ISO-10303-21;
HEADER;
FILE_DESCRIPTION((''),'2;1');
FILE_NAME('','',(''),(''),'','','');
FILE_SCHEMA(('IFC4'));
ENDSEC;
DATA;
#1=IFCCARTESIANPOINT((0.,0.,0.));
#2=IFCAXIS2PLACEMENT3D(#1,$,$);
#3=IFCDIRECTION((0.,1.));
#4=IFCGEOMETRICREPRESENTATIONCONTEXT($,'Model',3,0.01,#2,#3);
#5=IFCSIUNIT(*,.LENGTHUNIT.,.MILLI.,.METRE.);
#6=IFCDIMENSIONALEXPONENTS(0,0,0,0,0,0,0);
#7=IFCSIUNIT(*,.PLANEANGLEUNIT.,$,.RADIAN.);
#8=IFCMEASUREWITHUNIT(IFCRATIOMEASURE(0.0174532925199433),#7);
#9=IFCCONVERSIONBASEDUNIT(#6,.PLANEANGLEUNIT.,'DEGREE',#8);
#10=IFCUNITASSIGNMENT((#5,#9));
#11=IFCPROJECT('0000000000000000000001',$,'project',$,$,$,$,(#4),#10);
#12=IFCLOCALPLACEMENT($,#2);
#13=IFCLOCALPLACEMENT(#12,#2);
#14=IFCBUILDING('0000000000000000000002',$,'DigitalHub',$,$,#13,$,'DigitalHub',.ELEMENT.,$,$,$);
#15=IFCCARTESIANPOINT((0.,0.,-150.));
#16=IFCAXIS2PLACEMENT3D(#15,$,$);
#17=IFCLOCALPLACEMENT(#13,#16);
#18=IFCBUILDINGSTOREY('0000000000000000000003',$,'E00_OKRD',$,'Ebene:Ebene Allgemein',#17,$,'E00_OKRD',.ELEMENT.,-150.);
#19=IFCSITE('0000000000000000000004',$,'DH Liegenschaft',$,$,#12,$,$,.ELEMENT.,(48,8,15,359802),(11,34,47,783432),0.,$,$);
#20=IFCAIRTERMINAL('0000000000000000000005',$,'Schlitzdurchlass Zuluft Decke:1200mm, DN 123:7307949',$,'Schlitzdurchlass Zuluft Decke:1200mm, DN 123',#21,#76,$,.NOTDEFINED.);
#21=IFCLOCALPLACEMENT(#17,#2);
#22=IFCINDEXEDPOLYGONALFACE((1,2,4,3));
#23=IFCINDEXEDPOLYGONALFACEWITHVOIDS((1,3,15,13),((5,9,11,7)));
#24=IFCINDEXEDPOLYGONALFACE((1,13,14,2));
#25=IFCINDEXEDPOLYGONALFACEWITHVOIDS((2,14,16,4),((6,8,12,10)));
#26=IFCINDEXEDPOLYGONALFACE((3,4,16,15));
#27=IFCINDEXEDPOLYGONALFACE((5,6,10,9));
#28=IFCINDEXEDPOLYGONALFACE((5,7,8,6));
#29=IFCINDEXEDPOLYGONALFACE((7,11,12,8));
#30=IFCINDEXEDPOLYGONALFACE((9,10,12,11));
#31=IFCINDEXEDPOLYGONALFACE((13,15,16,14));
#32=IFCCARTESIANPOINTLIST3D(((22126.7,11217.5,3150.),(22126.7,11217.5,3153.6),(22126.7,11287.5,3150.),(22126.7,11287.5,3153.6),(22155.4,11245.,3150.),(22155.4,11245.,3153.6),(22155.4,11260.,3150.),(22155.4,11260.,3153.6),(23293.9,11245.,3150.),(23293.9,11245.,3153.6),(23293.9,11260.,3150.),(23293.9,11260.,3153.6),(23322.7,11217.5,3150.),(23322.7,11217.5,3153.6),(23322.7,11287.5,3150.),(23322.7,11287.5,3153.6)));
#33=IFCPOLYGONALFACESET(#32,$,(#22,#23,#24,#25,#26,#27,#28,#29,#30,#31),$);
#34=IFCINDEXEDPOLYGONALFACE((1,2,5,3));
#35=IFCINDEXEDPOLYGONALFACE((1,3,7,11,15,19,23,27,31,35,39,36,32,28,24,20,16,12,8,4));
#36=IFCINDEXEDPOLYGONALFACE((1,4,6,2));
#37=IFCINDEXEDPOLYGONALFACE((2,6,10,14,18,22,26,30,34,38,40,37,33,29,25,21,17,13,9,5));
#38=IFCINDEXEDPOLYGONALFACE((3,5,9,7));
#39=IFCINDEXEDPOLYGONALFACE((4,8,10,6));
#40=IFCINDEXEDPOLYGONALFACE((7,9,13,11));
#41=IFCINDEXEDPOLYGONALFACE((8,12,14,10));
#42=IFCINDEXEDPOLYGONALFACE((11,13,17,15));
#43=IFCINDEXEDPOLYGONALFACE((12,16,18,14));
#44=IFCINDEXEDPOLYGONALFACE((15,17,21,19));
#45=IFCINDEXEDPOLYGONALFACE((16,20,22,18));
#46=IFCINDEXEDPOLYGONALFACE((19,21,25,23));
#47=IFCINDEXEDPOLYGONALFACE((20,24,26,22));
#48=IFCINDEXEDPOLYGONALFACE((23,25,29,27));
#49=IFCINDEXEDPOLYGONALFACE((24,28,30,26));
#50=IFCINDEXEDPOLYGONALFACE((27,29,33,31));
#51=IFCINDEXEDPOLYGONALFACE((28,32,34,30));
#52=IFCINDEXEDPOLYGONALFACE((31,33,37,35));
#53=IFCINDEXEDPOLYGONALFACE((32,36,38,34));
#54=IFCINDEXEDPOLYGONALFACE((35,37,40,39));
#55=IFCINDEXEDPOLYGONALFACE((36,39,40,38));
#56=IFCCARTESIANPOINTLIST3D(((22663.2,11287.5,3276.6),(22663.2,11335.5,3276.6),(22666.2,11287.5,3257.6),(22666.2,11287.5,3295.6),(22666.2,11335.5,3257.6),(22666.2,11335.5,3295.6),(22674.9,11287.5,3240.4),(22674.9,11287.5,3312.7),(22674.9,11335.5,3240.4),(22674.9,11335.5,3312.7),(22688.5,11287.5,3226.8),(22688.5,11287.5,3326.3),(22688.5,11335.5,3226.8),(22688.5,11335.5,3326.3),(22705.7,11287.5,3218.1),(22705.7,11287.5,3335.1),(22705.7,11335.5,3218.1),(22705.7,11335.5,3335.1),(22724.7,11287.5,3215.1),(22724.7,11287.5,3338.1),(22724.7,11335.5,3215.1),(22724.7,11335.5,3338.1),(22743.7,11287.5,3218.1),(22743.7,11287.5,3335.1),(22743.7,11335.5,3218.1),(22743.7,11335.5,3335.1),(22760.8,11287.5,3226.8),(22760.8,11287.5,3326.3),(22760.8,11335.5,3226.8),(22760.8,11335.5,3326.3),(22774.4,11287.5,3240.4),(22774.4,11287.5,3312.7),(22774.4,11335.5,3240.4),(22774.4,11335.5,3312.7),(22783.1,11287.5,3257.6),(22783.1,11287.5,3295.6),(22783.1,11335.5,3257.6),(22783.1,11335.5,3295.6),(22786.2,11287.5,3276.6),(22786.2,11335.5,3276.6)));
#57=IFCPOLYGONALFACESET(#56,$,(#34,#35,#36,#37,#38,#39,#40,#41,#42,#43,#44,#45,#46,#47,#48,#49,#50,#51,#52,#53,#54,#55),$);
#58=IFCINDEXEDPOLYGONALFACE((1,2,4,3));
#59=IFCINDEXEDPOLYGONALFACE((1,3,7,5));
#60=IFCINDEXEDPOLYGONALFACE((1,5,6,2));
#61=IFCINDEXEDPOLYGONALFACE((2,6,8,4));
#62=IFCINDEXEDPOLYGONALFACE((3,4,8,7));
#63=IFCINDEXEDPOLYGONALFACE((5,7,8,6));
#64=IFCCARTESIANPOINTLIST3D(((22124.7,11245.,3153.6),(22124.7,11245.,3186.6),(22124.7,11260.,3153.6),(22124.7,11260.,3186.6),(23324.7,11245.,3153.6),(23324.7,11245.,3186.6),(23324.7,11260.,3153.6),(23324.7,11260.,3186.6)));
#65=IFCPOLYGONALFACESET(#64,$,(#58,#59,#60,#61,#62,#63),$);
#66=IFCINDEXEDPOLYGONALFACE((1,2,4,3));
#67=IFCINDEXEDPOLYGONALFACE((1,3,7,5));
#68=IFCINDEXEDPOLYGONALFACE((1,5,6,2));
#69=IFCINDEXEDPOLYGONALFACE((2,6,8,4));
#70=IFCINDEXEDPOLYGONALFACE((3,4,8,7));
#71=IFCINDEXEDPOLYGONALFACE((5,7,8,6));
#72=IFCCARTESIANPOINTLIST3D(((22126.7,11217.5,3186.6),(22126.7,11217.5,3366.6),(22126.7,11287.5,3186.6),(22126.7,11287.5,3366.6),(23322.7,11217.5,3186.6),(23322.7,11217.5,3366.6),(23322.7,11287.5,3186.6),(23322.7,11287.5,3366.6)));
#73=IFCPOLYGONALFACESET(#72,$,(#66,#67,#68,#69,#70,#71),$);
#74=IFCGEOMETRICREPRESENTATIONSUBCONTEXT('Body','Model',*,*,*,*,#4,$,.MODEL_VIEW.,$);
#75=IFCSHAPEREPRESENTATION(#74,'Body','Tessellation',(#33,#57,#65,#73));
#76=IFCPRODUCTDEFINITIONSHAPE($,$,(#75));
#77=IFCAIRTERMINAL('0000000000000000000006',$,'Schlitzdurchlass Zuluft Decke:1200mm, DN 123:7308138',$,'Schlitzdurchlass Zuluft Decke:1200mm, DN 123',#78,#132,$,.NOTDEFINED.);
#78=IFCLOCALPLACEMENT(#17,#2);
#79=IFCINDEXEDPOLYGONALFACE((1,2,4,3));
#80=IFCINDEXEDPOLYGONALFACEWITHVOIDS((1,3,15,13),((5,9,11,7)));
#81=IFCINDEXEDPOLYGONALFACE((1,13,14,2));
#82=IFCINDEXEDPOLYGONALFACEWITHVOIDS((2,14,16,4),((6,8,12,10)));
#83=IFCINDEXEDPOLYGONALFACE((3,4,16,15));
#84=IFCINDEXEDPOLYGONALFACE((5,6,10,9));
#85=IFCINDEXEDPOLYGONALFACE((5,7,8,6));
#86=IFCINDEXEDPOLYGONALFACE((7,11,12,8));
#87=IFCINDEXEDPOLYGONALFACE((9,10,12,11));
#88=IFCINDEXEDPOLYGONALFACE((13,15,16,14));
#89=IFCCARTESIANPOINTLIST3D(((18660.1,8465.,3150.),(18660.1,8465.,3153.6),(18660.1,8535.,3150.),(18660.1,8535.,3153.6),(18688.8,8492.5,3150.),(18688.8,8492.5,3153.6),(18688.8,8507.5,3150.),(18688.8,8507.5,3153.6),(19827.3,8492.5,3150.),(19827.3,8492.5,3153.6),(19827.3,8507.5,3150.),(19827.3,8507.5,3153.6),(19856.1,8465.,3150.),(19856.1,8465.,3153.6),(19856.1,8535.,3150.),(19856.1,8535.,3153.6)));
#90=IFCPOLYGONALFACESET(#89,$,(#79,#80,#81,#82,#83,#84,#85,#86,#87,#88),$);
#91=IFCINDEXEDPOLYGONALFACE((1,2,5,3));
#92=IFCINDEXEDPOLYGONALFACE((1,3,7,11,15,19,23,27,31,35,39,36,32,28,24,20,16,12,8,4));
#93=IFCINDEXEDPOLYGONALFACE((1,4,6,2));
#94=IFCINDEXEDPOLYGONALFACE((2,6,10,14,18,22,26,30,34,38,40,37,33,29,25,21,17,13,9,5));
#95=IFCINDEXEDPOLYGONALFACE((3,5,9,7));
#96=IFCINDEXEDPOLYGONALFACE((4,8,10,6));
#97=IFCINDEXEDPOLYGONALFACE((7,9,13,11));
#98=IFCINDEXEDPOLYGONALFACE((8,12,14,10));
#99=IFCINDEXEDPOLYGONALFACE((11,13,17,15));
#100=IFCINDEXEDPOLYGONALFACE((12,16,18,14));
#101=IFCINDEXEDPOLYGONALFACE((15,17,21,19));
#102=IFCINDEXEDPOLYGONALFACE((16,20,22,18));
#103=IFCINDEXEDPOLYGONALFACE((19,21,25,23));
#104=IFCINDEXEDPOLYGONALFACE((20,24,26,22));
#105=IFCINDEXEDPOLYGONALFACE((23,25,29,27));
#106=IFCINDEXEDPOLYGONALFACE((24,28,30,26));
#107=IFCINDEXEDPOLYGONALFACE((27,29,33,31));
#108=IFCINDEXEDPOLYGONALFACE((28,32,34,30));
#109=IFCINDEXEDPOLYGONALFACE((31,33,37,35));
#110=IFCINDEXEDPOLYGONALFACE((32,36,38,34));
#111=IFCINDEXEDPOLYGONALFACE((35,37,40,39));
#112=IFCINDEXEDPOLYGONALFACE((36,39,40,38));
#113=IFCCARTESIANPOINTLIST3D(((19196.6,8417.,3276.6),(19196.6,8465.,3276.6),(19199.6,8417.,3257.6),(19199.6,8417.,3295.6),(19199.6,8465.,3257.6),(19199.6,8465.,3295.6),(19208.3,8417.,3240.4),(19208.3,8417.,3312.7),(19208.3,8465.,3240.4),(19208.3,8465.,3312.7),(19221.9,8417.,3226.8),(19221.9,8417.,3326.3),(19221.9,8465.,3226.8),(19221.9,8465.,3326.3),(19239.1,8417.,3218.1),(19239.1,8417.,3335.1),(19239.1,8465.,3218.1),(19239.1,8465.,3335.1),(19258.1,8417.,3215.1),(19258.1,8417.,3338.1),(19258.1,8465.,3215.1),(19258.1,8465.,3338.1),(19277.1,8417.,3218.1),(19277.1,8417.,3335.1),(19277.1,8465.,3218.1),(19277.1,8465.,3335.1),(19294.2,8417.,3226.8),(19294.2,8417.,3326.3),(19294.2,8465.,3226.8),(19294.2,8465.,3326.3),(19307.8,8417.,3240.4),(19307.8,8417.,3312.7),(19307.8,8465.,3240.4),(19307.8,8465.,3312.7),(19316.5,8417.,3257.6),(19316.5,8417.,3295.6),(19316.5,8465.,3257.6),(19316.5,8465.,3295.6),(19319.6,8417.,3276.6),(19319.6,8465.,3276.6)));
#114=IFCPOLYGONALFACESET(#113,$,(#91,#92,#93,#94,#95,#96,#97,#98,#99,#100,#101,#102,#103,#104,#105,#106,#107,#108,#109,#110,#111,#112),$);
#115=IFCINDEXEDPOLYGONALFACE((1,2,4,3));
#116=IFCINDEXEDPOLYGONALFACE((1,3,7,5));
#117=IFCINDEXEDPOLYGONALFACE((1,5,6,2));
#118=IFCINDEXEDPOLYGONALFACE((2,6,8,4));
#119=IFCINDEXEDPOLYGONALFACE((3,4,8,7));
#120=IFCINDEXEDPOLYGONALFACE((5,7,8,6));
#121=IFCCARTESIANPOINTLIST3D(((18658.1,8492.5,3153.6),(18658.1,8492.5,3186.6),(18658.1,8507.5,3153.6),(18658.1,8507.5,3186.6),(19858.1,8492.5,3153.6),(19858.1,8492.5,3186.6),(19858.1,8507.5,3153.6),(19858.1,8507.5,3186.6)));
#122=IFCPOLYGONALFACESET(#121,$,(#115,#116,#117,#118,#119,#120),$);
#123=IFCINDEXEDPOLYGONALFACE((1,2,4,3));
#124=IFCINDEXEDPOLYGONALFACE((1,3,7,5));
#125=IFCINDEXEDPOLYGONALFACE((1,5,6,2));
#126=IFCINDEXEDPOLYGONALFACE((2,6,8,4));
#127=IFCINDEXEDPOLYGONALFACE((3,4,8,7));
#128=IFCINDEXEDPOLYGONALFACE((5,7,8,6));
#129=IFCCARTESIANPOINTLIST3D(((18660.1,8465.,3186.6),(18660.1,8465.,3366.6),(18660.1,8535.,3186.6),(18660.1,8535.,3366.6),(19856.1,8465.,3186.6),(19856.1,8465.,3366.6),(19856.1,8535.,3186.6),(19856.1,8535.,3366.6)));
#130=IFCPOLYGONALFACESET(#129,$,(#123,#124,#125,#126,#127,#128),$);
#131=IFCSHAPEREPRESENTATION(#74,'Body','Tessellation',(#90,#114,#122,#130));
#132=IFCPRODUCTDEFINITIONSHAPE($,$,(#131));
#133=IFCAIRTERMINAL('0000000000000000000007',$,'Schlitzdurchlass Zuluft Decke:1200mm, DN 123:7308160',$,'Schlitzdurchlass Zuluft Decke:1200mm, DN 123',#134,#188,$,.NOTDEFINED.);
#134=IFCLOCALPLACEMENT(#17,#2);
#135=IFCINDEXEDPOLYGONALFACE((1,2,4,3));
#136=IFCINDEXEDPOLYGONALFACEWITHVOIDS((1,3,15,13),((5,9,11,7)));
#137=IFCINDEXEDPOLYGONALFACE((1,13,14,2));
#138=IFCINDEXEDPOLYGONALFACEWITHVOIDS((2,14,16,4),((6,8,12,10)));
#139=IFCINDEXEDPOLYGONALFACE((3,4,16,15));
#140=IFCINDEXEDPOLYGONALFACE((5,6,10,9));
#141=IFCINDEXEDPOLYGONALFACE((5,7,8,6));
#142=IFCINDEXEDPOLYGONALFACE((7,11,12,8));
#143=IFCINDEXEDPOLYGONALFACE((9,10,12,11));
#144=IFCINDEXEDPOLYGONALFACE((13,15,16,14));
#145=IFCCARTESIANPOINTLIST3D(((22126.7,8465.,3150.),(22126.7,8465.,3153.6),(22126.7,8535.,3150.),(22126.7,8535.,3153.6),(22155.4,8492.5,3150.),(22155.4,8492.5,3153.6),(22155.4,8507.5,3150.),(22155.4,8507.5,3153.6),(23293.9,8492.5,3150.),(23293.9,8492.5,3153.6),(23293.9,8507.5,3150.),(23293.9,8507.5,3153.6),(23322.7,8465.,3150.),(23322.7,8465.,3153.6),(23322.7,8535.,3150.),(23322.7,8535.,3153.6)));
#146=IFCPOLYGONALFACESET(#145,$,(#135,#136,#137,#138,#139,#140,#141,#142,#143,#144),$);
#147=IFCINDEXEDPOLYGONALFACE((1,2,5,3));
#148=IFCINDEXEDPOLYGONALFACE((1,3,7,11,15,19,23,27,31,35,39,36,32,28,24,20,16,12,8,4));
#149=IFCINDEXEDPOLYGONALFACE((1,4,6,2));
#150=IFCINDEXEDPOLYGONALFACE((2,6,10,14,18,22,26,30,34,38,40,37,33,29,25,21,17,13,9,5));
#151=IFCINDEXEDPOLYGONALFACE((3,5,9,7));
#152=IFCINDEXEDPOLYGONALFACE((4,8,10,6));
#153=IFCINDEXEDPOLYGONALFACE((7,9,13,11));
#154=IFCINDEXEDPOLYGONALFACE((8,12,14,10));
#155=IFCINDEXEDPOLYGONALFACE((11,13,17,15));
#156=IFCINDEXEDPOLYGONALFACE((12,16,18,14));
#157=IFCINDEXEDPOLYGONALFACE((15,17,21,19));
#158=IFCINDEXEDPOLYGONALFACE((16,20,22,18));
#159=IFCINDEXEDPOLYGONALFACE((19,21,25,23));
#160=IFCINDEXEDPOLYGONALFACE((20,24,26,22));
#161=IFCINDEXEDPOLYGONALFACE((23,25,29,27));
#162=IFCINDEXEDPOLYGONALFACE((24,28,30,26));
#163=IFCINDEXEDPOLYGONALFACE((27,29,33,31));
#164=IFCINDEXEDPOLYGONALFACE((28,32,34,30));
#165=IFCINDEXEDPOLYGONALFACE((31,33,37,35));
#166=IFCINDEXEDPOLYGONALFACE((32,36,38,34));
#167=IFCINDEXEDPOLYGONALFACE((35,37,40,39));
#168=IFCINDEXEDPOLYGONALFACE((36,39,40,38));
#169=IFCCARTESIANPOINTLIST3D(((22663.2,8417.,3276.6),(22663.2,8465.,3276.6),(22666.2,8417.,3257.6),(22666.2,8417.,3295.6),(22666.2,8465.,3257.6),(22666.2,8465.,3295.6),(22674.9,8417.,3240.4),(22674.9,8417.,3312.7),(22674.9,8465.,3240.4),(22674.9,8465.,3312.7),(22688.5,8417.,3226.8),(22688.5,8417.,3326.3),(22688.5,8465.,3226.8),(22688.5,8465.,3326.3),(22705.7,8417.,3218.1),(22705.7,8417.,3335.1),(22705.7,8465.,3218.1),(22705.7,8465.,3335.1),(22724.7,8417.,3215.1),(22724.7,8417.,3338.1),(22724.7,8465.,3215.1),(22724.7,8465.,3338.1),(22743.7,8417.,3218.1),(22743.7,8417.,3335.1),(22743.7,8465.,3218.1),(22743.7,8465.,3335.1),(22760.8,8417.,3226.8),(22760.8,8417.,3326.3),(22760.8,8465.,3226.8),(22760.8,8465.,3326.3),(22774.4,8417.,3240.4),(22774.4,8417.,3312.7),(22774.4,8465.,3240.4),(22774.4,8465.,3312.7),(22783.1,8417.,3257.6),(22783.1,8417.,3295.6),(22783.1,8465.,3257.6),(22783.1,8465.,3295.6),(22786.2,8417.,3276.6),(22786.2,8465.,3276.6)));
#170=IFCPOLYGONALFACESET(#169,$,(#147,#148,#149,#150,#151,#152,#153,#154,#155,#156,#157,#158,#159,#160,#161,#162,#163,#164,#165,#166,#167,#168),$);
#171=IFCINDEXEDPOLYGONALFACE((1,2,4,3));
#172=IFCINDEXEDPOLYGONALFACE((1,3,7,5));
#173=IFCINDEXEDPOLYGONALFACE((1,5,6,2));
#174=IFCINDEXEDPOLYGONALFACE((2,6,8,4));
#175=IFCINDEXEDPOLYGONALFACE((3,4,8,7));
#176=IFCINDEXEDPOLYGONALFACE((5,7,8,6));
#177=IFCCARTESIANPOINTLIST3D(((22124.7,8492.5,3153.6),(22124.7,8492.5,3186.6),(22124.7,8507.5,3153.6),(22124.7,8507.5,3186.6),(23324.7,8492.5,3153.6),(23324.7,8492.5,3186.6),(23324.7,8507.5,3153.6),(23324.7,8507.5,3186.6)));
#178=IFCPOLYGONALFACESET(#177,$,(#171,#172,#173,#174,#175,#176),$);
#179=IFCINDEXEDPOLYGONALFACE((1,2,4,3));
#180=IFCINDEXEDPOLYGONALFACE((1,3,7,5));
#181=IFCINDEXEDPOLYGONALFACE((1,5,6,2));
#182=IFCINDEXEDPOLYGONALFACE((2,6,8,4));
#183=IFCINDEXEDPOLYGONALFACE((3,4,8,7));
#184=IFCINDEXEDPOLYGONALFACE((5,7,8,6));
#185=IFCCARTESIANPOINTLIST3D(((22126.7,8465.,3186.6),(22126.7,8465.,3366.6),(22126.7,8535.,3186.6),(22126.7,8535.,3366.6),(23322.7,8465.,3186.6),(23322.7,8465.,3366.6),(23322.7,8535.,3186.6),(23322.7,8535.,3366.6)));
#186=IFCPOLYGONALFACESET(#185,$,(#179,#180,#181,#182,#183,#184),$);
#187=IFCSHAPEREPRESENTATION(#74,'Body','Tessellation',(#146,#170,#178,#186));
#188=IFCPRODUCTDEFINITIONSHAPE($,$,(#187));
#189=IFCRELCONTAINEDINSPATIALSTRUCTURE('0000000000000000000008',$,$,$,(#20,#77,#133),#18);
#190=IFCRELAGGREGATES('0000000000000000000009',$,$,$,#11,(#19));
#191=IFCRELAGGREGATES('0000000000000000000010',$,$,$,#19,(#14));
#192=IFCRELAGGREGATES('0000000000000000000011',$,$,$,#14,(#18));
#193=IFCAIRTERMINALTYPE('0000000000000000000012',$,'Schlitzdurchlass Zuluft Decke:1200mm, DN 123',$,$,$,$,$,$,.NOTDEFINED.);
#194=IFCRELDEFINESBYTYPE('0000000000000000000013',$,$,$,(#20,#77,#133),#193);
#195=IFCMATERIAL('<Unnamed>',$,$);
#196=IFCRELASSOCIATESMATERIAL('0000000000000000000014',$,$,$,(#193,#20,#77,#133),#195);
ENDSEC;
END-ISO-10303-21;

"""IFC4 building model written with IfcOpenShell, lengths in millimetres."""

from ifc_helpers import new_model, entity, si_unit, converted_unit, direction, frame, origin, place, context, subcontext, project, spatial, indexed_curve, outline, extrude, source, transform, mapped, material, type_object, type_shapes, element, save


model = new_model("IFC4")

# Units and contexts
model_context = context("Model", 3, precision=0.01, world=origin(), true_north=direction((0.0, 1.0)))
body_context = subcontext(model_context, "Body", "Model", "MODEL_VIEW")
ifc_project = project(units=[si_unit("LENGTHUNIT", "METRE", prefix="MILLI"), converted_unit("PLANEANGLEUNIT", "DEGREE", entity("IfcRatioMeasure", 0.0174532925199433), si_unit("PLANEANGLEUNIT", "RADIAN"), dimensions=[0, 0, 0, 0, 0, 0, 0])], contexts=[model_context])

# Site, building, storey
site_placement = place(None, origin())
site = spatial("IfcSite", under=ifc_project, at=site_placement, Name="DH Liegenschaft", CompositionType="ELEMENT", RefLatitude=(48, 8, 15, 359802), RefLongitude=(11, 34, 47, 783432), RefElevation=0.0)
building_placement = place(site_placement, origin())
building = spatial("IfcBuilding", under=site, at=building_placement, Name="DigitalHub", LongName="DigitalHub", CompositionType="ELEMENT")
storey_placement = place(building_placement, frame((0.0, 0.0, -150.0)))
storey = spatial("IfcBuildingStorey", under=building, at=storey_placement, Name="E00_OKRD", ObjectType="Ebene:Ebene Allgemein", LongName="E00_OKRD", CompositionType="ELEMENT", Elevation=-150.0)

# Air terminals
ifc_material_1 = material(Name="<Unnamed>")
air_terminal_type_1 = type_object("IfcAirTerminalType", Name="Schlitzdurchlass Zuluft Decke:1200mm, DN 123", PredefinedType="NOTDEFINED", material=ifc_material_1)
shared_shape_1 = source(origin(), body_context, "Body", "SweptSolid", [
    extrude(outline(indexed_curve([(-598.0, -35.0), (598.0, -35.0), (598.0, 35.0), (-598.0, 35.0), (-598.0, -35.0)], self_intersect=False), holes=[indexed_curve([(-569.2, -7.5), (-569.2, 7.5), (569.2, 7.5), (569.2, -7.5), (-569.2, -7.5)], self_intersect=False)]), frame((600.0, 35.0, 0.0), z_axis=(0.0, 0.0, 1.0), x_axis=(-1.0, 0.0, 0.0)), (0.0, 0.0, 1.0), 3.6),
    extrude(outline(indexed_curve([(61.5, 0.0), (58.5, 19.0), (49.8, 36.1), (36.1, 49.8), (19.0, 58.5), (0.0, 61.5), (-19.0, 58.5), (-36.1, 49.8), (-49.8, 36.1), (-58.5, 19.0), (-61.5, 0.0), (-58.5, -19.0), (-49.8, -36.1), (-36.1, -49.8), (-19.0, -58.5), (0.0, -61.5), (19.0, -58.5), (36.1, -49.8), (49.8, -36.1), (58.5, -19.0), (61.5, 0.0)], self_intersect=False)), frame((600.0, 70.0, 126.6), z_axis=(0.0, 1.0, 0.0), x_axis=(-1.0, 0.0, 0.0)), (0.0, 0.0, 1.0), 48.0),
    extrude(outline(indexed_curve([(-600.0, -7.5), (600.0, -7.5), (600.0, 7.5), (-600.0, 7.5), (-600.0, -7.5)], self_intersect=False)), frame((600.0, 35.0, 3.6), z_axis=(0.0, 0.0, 1.0), x_axis=(-1.0, 0.0, 0.0)), (0.0, 0.0, 1.0), 33.0),
    extrude(outline(indexed_curve([(-598.0, -35.0), (598.0, -35.0), (598.0, 35.0), (-598.0, 35.0), (-598.0, -35.0)], self_intersect=False)), frame((600.0, 35.0, 36.6), z_axis=(0.0, 0.0, 1.0), x_axis=(-1.0, 0.0, 0.0)), (0.0, 0.0, 1.0), 180.0),
])
type_shapes(air_terminal_type_1, [shared_shape_1])
air_terminal_placement = place(storey_placement, frame((22124.7, 11217.5, 3150.0)))
element("IfcAirTerminal", 1, at=air_terminal_placement, inside=storey, type_object=air_terminal_type_1, material=ifc_material_1, Name="Schlitzdurchlass Zuluft Decke:1200mm, DN 123:7307949", ObjectType="Schlitzdurchlass Zuluft Decke:1200mm, DN 123", PredefinedType="NOTDEFINED", context=body_context, shape_type="MappedRepresentation", body=[
    mapped(shared_shape_1, transform((0.0, 0.0, 0.0), scale=1.0)),
])
for number, where, z_axis, x_axis, name in (
    (2, (19858.1, 8535.0, 3150.0), (0.0, 0.0, 1.0), (-1.0, 0.0, 0.0), "Schlitzdurchlass Zuluft Decke:1200mm, DN 123:7308138"),
    (3, (23324.7, 8535.0, 3150.0), (0.0, 0.0, 1.0), (-1.0, 0.0, 0.0), "Schlitzdurchlass Zuluft Decke:1200mm, DN 123:7308160"),
):
    element("IfcAirTerminal", number, at=place(storey_placement, frame(where, z_axis=z_axis, x_axis=x_axis)), inside=storey, type_object=air_terminal_type_1, material=ifc_material_1, Name=name, ObjectType="Schlitzdurchlass Zuluft Decke:1200mm, DN 123", PredefinedType="NOTDEFINED", context=body_context, shape_type="MappedRepresentation", body=[
        mapped(shared_shape_1, transform((0.0, 0.0, 0.0), scale=1.0)),
    ])

save(model, "model.ifc")
